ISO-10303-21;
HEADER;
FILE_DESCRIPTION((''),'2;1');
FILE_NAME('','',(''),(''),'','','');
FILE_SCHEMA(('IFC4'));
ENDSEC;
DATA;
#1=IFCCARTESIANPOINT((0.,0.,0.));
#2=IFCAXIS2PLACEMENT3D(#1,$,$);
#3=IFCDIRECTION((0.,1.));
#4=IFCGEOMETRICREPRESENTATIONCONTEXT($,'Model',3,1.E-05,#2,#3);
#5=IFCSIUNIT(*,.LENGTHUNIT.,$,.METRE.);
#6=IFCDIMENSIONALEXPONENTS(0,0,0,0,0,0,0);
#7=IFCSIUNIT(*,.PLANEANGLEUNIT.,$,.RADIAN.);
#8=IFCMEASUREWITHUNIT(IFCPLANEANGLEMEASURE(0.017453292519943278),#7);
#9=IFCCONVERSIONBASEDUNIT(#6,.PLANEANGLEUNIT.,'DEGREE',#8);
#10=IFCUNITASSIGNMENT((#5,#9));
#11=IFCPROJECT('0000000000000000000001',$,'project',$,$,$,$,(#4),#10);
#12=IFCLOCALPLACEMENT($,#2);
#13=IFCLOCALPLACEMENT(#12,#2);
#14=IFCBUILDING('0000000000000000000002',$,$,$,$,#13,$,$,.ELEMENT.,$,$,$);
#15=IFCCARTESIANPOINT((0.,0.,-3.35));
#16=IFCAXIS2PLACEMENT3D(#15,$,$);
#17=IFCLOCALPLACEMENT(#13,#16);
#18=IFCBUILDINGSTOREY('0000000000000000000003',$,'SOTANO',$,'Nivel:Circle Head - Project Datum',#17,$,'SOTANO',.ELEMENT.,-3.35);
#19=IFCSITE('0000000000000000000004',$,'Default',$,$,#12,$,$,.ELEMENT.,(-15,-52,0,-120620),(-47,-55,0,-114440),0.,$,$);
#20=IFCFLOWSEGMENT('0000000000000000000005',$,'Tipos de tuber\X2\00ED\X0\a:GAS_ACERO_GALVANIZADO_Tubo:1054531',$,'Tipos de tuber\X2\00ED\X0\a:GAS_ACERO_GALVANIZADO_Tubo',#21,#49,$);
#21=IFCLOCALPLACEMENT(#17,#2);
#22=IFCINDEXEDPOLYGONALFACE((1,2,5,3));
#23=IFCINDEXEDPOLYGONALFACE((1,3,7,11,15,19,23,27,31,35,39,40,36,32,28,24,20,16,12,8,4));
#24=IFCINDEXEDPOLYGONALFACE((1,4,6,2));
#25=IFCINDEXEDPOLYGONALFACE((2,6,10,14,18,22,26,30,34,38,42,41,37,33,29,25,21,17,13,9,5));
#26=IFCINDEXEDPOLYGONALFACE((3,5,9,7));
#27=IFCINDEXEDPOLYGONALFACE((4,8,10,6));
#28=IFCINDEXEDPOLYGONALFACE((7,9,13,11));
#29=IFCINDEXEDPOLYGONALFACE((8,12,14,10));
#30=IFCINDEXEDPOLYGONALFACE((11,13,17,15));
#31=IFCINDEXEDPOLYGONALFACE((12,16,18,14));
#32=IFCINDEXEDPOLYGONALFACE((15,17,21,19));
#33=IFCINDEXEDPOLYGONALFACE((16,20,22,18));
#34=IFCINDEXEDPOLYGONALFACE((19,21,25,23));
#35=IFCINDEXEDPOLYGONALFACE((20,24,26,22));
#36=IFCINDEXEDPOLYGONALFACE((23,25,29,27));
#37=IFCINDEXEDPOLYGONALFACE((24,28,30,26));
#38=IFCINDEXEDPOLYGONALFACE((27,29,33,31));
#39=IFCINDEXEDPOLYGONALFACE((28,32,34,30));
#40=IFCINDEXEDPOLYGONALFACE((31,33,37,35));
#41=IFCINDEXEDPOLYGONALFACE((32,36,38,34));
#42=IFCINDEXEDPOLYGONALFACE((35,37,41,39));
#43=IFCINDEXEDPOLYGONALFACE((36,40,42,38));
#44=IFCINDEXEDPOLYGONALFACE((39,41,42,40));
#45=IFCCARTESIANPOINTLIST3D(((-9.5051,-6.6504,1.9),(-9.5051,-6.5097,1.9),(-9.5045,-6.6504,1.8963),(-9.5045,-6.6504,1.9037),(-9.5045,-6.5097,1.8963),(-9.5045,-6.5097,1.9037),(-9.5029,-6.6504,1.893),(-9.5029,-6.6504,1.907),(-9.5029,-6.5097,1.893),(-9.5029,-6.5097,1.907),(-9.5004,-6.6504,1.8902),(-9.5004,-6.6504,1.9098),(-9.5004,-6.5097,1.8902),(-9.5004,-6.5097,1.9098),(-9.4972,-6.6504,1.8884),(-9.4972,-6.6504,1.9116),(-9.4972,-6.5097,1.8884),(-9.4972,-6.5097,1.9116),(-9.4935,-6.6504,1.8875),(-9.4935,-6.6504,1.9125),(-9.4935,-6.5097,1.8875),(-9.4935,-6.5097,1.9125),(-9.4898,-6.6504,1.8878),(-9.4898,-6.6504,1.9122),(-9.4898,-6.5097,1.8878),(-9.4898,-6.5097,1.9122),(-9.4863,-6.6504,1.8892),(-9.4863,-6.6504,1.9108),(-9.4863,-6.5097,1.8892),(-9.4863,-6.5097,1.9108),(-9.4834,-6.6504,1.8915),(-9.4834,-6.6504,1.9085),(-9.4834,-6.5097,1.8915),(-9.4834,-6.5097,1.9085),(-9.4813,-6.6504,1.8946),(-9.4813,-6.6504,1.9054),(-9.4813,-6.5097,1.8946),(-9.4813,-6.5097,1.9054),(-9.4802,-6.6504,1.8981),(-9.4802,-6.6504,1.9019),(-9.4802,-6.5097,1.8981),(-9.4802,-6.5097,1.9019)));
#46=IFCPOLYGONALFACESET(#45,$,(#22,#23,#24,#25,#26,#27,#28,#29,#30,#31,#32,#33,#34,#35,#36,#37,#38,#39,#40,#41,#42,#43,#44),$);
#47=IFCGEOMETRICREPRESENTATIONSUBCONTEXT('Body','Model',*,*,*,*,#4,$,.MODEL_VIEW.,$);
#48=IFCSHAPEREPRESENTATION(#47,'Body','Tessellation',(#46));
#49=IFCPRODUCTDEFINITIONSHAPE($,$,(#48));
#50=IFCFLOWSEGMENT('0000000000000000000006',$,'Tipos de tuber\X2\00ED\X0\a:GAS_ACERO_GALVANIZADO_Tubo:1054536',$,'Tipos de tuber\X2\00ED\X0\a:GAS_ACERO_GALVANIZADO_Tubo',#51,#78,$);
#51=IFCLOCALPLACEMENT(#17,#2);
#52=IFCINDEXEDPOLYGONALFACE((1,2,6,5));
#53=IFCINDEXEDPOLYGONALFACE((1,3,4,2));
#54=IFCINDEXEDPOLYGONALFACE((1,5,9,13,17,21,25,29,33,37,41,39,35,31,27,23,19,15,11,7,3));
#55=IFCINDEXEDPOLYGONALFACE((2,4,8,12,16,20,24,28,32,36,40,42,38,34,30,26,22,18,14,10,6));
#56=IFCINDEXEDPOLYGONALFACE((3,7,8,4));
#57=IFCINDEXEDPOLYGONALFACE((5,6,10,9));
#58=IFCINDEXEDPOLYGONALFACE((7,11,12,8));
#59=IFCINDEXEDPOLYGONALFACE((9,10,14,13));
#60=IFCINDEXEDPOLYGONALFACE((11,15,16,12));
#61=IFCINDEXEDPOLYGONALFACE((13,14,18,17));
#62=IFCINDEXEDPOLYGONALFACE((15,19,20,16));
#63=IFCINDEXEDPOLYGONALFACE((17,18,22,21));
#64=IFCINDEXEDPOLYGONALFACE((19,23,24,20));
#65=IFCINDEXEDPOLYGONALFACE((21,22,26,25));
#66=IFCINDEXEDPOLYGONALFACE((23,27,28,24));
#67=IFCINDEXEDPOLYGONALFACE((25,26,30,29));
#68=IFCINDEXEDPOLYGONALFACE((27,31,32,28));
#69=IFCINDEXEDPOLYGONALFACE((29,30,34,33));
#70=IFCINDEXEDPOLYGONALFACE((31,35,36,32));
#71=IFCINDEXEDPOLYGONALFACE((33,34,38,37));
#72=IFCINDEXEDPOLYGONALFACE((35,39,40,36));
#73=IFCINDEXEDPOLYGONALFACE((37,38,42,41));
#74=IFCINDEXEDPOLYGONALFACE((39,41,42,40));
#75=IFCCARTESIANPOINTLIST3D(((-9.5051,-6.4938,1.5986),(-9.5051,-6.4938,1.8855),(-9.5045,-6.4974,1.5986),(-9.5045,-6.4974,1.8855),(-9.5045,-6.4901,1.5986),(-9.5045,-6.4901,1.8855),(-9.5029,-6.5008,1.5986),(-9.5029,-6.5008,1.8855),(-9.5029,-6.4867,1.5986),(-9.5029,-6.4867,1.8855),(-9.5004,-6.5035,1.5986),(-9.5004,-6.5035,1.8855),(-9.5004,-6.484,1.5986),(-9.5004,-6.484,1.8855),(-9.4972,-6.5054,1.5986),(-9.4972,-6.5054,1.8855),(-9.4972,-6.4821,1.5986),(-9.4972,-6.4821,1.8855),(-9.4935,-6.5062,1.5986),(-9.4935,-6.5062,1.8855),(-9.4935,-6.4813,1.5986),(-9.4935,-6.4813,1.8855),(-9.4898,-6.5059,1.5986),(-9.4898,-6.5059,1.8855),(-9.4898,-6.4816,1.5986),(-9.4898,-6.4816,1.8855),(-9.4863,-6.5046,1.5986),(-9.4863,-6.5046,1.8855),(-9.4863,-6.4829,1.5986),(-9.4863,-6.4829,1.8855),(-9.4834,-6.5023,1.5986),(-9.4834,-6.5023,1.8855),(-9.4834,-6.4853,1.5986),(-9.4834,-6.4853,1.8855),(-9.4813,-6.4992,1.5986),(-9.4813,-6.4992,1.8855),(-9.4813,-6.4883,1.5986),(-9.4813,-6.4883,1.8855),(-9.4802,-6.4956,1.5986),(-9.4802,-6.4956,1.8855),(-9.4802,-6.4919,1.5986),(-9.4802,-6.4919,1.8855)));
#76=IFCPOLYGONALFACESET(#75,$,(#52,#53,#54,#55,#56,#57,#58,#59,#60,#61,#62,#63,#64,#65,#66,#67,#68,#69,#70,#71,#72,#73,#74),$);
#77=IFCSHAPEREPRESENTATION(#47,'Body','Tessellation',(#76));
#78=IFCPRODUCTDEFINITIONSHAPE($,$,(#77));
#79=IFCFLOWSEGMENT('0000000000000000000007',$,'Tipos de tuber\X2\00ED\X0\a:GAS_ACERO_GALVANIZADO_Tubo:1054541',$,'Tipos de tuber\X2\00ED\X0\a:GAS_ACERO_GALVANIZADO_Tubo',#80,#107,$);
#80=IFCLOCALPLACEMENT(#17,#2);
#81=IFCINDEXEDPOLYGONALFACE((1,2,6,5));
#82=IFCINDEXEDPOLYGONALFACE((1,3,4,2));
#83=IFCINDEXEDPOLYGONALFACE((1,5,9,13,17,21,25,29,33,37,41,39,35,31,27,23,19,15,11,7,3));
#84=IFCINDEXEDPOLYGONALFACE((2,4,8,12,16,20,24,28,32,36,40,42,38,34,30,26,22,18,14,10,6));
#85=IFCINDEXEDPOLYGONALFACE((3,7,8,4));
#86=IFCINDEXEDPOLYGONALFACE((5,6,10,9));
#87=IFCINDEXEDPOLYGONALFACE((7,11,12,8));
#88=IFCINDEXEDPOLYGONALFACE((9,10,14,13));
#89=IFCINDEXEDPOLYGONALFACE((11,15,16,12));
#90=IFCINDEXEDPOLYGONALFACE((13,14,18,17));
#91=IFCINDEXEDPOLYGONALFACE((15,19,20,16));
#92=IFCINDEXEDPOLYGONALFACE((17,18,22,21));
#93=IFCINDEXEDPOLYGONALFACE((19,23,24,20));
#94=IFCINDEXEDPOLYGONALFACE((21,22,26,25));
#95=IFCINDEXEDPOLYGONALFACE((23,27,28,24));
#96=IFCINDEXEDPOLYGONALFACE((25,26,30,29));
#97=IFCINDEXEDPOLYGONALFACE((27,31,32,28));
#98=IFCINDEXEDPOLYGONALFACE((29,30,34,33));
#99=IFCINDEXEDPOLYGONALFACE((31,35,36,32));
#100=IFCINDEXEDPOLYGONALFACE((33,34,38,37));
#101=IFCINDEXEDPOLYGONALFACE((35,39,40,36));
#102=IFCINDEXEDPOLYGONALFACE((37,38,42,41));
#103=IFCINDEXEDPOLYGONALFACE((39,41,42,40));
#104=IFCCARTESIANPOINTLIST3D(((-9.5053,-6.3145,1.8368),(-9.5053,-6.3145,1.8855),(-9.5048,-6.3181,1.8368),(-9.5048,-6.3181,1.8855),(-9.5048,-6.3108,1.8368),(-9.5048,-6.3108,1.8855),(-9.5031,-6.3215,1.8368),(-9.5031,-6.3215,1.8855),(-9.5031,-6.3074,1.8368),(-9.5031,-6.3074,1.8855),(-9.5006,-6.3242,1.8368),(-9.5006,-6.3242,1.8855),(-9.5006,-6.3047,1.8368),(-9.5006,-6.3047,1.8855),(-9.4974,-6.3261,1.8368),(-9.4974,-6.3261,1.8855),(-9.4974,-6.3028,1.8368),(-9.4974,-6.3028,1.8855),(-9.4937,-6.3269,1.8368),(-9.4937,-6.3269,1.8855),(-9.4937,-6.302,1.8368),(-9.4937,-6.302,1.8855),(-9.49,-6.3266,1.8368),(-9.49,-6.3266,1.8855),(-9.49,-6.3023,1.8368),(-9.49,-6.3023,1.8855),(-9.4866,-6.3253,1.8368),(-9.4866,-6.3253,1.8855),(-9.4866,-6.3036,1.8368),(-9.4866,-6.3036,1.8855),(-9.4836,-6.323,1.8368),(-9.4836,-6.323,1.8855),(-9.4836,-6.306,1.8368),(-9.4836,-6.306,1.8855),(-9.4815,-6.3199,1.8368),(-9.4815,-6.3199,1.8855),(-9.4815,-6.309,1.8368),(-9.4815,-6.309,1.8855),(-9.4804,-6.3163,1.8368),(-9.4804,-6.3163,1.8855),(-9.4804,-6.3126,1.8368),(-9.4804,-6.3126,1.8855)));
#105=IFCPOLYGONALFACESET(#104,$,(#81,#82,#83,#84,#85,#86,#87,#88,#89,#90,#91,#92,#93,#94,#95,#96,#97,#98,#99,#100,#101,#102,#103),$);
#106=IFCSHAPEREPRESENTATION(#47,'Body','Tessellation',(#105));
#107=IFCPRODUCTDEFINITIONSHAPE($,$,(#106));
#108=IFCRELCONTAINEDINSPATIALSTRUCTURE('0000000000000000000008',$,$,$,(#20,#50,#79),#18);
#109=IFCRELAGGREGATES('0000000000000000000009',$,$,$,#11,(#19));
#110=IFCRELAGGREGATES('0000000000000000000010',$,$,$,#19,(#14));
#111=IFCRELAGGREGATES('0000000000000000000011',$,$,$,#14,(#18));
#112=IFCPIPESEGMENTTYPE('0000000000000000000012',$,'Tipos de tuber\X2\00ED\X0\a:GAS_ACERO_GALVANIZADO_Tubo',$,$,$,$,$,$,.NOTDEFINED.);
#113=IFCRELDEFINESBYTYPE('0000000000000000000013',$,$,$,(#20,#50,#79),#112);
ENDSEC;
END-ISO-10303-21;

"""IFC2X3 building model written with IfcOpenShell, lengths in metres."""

from ifc_helpers import new_model, entity, si_unit, converted_unit, direction, frame, frame_2d, origin, origin_2d_with_axis, place, context, subcontext, project, spatial, circle, extrude, type_object, element, save


model = new_model("IFC2X3")

# Units and contexts
model_context = context("Model", 3, precision=1e-05, world=origin(), true_north=direction((0.0, 1.0)))
body_context = subcontext(model_context, "Body", "Model", "MODEL_VIEW")
ifc_project = project(units=[si_unit("LENGTHUNIT", "METRE"), converted_unit("PLANEANGLEUNIT", "DEGREE", entity("IfcPlaneAngleMeasure", 0.017453292519943278), si_unit("PLANEANGLEUNIT", "RADIAN"), dimensions=[0, 0, 0, 0, 0, 0, 0])], contexts=[model_context])

# Site, building, storey
site_placement = place(None, origin())
site = spatial("IfcSite", under=ifc_project, at=site_placement, Name="Default", CompositionType="ELEMENT", RefLatitude=(-15, -52, 0, -120620), RefLongitude=(-47, -55, 0, -114440), RefElevation=0.0)
building_placement = place(site_placement, origin())
building = spatial("IfcBuilding", under=site, at=building_placement, CompositionType="ELEMENT")
storey_placement = place(building_placement, frame((0.0, 0.0, -3.35)))
storey = spatial("IfcBuildingStorey", under=building, at=storey_placement, Name="SOTANO", ObjectType="Nivel:Circle Head - Project Datum", LongName="SOTANO", CompositionType="ELEMENT", Elevation=-3.35)

# Flow segments
pipe_segment_type_1 = type_object("IfcPipeSegmentType", Name="Tipos de tubería:GAS_ACERO_GALVANIZADO_Tubo", PredefinedType="NOTDEFINED")
flow_segment_1_placement = place(storey_placement, origin())
element("IfcFlowSegment", 1, at=flow_segment_1_placement, inside=storey, type_object=pipe_segment_type_1, Name="Tipos de tubería:GAS_ACERO_GALVANIZADO_Tubo:1054531", ObjectType="Tipos de tubería:GAS_ACERO_GALVANIZADO_Tubo", context=body_context, shape_type="SweptSolid", body=[
    extrude(circle(Radius=0.0125, at=frame_2d((0.0, 0.0), x_axis=(1.0, 0.0))), frame((-9.4926, -6.6504, 1.9), z_axis=(-0.000009, 1.0, 0.0), x_axis=(-1.0, -0.000009, 0.0)), (0.0, 0.0, 1.0), 0.1408),
])
flow_segment_2_placement = place(storey_placement, origin())
element("IfcFlowSegment", 2, at=flow_segment_2_placement, inside=storey, type_object=pipe_segment_type_1, Name="Tipos de tubería:GAS_ACERO_GALVANIZADO_Tubo:1054536", ObjectType="Tipos de tubería:GAS_ACERO_GALVANIZADO_Tubo", context=body_context, shape_type="SweptSolid", body=[
    extrude(circle(Radius=0.0125, at=origin_2d_with_axis()), frame((-9.4926, -6.4938, 1.5986), z_axis=(0.0, 0.0, 1.0), x_axis=(-1.0, 0.0, 0.0)), (0.0, 0.0, 1.0), 0.2869),
])
flow_segment_3_placement = place(storey_placement, origin())
element("IfcFlowSegment", 3, at=flow_segment_3_placement, inside=storey, type_object=pipe_segment_type_1, Name="Tipos de tubería:GAS_ACERO_GALVANIZADO_Tubo:1054541", ObjectType="Tipos de tubería:GAS_ACERO_GALVANIZADO_Tubo", context=body_context, shape_type="SweptSolid", body=[
    extrude(circle(Radius=0.0125, at=origin_2d_with_axis()), frame((-9.4928, -6.3145, 1.8368), z_axis=(-0.000001, 0.0, 1.0), x_axis=(-1.0, 0.0, -0.000001)), (0.0, 0.0, 1.0), 0.0487),
])

save(model, "model.ifc")
